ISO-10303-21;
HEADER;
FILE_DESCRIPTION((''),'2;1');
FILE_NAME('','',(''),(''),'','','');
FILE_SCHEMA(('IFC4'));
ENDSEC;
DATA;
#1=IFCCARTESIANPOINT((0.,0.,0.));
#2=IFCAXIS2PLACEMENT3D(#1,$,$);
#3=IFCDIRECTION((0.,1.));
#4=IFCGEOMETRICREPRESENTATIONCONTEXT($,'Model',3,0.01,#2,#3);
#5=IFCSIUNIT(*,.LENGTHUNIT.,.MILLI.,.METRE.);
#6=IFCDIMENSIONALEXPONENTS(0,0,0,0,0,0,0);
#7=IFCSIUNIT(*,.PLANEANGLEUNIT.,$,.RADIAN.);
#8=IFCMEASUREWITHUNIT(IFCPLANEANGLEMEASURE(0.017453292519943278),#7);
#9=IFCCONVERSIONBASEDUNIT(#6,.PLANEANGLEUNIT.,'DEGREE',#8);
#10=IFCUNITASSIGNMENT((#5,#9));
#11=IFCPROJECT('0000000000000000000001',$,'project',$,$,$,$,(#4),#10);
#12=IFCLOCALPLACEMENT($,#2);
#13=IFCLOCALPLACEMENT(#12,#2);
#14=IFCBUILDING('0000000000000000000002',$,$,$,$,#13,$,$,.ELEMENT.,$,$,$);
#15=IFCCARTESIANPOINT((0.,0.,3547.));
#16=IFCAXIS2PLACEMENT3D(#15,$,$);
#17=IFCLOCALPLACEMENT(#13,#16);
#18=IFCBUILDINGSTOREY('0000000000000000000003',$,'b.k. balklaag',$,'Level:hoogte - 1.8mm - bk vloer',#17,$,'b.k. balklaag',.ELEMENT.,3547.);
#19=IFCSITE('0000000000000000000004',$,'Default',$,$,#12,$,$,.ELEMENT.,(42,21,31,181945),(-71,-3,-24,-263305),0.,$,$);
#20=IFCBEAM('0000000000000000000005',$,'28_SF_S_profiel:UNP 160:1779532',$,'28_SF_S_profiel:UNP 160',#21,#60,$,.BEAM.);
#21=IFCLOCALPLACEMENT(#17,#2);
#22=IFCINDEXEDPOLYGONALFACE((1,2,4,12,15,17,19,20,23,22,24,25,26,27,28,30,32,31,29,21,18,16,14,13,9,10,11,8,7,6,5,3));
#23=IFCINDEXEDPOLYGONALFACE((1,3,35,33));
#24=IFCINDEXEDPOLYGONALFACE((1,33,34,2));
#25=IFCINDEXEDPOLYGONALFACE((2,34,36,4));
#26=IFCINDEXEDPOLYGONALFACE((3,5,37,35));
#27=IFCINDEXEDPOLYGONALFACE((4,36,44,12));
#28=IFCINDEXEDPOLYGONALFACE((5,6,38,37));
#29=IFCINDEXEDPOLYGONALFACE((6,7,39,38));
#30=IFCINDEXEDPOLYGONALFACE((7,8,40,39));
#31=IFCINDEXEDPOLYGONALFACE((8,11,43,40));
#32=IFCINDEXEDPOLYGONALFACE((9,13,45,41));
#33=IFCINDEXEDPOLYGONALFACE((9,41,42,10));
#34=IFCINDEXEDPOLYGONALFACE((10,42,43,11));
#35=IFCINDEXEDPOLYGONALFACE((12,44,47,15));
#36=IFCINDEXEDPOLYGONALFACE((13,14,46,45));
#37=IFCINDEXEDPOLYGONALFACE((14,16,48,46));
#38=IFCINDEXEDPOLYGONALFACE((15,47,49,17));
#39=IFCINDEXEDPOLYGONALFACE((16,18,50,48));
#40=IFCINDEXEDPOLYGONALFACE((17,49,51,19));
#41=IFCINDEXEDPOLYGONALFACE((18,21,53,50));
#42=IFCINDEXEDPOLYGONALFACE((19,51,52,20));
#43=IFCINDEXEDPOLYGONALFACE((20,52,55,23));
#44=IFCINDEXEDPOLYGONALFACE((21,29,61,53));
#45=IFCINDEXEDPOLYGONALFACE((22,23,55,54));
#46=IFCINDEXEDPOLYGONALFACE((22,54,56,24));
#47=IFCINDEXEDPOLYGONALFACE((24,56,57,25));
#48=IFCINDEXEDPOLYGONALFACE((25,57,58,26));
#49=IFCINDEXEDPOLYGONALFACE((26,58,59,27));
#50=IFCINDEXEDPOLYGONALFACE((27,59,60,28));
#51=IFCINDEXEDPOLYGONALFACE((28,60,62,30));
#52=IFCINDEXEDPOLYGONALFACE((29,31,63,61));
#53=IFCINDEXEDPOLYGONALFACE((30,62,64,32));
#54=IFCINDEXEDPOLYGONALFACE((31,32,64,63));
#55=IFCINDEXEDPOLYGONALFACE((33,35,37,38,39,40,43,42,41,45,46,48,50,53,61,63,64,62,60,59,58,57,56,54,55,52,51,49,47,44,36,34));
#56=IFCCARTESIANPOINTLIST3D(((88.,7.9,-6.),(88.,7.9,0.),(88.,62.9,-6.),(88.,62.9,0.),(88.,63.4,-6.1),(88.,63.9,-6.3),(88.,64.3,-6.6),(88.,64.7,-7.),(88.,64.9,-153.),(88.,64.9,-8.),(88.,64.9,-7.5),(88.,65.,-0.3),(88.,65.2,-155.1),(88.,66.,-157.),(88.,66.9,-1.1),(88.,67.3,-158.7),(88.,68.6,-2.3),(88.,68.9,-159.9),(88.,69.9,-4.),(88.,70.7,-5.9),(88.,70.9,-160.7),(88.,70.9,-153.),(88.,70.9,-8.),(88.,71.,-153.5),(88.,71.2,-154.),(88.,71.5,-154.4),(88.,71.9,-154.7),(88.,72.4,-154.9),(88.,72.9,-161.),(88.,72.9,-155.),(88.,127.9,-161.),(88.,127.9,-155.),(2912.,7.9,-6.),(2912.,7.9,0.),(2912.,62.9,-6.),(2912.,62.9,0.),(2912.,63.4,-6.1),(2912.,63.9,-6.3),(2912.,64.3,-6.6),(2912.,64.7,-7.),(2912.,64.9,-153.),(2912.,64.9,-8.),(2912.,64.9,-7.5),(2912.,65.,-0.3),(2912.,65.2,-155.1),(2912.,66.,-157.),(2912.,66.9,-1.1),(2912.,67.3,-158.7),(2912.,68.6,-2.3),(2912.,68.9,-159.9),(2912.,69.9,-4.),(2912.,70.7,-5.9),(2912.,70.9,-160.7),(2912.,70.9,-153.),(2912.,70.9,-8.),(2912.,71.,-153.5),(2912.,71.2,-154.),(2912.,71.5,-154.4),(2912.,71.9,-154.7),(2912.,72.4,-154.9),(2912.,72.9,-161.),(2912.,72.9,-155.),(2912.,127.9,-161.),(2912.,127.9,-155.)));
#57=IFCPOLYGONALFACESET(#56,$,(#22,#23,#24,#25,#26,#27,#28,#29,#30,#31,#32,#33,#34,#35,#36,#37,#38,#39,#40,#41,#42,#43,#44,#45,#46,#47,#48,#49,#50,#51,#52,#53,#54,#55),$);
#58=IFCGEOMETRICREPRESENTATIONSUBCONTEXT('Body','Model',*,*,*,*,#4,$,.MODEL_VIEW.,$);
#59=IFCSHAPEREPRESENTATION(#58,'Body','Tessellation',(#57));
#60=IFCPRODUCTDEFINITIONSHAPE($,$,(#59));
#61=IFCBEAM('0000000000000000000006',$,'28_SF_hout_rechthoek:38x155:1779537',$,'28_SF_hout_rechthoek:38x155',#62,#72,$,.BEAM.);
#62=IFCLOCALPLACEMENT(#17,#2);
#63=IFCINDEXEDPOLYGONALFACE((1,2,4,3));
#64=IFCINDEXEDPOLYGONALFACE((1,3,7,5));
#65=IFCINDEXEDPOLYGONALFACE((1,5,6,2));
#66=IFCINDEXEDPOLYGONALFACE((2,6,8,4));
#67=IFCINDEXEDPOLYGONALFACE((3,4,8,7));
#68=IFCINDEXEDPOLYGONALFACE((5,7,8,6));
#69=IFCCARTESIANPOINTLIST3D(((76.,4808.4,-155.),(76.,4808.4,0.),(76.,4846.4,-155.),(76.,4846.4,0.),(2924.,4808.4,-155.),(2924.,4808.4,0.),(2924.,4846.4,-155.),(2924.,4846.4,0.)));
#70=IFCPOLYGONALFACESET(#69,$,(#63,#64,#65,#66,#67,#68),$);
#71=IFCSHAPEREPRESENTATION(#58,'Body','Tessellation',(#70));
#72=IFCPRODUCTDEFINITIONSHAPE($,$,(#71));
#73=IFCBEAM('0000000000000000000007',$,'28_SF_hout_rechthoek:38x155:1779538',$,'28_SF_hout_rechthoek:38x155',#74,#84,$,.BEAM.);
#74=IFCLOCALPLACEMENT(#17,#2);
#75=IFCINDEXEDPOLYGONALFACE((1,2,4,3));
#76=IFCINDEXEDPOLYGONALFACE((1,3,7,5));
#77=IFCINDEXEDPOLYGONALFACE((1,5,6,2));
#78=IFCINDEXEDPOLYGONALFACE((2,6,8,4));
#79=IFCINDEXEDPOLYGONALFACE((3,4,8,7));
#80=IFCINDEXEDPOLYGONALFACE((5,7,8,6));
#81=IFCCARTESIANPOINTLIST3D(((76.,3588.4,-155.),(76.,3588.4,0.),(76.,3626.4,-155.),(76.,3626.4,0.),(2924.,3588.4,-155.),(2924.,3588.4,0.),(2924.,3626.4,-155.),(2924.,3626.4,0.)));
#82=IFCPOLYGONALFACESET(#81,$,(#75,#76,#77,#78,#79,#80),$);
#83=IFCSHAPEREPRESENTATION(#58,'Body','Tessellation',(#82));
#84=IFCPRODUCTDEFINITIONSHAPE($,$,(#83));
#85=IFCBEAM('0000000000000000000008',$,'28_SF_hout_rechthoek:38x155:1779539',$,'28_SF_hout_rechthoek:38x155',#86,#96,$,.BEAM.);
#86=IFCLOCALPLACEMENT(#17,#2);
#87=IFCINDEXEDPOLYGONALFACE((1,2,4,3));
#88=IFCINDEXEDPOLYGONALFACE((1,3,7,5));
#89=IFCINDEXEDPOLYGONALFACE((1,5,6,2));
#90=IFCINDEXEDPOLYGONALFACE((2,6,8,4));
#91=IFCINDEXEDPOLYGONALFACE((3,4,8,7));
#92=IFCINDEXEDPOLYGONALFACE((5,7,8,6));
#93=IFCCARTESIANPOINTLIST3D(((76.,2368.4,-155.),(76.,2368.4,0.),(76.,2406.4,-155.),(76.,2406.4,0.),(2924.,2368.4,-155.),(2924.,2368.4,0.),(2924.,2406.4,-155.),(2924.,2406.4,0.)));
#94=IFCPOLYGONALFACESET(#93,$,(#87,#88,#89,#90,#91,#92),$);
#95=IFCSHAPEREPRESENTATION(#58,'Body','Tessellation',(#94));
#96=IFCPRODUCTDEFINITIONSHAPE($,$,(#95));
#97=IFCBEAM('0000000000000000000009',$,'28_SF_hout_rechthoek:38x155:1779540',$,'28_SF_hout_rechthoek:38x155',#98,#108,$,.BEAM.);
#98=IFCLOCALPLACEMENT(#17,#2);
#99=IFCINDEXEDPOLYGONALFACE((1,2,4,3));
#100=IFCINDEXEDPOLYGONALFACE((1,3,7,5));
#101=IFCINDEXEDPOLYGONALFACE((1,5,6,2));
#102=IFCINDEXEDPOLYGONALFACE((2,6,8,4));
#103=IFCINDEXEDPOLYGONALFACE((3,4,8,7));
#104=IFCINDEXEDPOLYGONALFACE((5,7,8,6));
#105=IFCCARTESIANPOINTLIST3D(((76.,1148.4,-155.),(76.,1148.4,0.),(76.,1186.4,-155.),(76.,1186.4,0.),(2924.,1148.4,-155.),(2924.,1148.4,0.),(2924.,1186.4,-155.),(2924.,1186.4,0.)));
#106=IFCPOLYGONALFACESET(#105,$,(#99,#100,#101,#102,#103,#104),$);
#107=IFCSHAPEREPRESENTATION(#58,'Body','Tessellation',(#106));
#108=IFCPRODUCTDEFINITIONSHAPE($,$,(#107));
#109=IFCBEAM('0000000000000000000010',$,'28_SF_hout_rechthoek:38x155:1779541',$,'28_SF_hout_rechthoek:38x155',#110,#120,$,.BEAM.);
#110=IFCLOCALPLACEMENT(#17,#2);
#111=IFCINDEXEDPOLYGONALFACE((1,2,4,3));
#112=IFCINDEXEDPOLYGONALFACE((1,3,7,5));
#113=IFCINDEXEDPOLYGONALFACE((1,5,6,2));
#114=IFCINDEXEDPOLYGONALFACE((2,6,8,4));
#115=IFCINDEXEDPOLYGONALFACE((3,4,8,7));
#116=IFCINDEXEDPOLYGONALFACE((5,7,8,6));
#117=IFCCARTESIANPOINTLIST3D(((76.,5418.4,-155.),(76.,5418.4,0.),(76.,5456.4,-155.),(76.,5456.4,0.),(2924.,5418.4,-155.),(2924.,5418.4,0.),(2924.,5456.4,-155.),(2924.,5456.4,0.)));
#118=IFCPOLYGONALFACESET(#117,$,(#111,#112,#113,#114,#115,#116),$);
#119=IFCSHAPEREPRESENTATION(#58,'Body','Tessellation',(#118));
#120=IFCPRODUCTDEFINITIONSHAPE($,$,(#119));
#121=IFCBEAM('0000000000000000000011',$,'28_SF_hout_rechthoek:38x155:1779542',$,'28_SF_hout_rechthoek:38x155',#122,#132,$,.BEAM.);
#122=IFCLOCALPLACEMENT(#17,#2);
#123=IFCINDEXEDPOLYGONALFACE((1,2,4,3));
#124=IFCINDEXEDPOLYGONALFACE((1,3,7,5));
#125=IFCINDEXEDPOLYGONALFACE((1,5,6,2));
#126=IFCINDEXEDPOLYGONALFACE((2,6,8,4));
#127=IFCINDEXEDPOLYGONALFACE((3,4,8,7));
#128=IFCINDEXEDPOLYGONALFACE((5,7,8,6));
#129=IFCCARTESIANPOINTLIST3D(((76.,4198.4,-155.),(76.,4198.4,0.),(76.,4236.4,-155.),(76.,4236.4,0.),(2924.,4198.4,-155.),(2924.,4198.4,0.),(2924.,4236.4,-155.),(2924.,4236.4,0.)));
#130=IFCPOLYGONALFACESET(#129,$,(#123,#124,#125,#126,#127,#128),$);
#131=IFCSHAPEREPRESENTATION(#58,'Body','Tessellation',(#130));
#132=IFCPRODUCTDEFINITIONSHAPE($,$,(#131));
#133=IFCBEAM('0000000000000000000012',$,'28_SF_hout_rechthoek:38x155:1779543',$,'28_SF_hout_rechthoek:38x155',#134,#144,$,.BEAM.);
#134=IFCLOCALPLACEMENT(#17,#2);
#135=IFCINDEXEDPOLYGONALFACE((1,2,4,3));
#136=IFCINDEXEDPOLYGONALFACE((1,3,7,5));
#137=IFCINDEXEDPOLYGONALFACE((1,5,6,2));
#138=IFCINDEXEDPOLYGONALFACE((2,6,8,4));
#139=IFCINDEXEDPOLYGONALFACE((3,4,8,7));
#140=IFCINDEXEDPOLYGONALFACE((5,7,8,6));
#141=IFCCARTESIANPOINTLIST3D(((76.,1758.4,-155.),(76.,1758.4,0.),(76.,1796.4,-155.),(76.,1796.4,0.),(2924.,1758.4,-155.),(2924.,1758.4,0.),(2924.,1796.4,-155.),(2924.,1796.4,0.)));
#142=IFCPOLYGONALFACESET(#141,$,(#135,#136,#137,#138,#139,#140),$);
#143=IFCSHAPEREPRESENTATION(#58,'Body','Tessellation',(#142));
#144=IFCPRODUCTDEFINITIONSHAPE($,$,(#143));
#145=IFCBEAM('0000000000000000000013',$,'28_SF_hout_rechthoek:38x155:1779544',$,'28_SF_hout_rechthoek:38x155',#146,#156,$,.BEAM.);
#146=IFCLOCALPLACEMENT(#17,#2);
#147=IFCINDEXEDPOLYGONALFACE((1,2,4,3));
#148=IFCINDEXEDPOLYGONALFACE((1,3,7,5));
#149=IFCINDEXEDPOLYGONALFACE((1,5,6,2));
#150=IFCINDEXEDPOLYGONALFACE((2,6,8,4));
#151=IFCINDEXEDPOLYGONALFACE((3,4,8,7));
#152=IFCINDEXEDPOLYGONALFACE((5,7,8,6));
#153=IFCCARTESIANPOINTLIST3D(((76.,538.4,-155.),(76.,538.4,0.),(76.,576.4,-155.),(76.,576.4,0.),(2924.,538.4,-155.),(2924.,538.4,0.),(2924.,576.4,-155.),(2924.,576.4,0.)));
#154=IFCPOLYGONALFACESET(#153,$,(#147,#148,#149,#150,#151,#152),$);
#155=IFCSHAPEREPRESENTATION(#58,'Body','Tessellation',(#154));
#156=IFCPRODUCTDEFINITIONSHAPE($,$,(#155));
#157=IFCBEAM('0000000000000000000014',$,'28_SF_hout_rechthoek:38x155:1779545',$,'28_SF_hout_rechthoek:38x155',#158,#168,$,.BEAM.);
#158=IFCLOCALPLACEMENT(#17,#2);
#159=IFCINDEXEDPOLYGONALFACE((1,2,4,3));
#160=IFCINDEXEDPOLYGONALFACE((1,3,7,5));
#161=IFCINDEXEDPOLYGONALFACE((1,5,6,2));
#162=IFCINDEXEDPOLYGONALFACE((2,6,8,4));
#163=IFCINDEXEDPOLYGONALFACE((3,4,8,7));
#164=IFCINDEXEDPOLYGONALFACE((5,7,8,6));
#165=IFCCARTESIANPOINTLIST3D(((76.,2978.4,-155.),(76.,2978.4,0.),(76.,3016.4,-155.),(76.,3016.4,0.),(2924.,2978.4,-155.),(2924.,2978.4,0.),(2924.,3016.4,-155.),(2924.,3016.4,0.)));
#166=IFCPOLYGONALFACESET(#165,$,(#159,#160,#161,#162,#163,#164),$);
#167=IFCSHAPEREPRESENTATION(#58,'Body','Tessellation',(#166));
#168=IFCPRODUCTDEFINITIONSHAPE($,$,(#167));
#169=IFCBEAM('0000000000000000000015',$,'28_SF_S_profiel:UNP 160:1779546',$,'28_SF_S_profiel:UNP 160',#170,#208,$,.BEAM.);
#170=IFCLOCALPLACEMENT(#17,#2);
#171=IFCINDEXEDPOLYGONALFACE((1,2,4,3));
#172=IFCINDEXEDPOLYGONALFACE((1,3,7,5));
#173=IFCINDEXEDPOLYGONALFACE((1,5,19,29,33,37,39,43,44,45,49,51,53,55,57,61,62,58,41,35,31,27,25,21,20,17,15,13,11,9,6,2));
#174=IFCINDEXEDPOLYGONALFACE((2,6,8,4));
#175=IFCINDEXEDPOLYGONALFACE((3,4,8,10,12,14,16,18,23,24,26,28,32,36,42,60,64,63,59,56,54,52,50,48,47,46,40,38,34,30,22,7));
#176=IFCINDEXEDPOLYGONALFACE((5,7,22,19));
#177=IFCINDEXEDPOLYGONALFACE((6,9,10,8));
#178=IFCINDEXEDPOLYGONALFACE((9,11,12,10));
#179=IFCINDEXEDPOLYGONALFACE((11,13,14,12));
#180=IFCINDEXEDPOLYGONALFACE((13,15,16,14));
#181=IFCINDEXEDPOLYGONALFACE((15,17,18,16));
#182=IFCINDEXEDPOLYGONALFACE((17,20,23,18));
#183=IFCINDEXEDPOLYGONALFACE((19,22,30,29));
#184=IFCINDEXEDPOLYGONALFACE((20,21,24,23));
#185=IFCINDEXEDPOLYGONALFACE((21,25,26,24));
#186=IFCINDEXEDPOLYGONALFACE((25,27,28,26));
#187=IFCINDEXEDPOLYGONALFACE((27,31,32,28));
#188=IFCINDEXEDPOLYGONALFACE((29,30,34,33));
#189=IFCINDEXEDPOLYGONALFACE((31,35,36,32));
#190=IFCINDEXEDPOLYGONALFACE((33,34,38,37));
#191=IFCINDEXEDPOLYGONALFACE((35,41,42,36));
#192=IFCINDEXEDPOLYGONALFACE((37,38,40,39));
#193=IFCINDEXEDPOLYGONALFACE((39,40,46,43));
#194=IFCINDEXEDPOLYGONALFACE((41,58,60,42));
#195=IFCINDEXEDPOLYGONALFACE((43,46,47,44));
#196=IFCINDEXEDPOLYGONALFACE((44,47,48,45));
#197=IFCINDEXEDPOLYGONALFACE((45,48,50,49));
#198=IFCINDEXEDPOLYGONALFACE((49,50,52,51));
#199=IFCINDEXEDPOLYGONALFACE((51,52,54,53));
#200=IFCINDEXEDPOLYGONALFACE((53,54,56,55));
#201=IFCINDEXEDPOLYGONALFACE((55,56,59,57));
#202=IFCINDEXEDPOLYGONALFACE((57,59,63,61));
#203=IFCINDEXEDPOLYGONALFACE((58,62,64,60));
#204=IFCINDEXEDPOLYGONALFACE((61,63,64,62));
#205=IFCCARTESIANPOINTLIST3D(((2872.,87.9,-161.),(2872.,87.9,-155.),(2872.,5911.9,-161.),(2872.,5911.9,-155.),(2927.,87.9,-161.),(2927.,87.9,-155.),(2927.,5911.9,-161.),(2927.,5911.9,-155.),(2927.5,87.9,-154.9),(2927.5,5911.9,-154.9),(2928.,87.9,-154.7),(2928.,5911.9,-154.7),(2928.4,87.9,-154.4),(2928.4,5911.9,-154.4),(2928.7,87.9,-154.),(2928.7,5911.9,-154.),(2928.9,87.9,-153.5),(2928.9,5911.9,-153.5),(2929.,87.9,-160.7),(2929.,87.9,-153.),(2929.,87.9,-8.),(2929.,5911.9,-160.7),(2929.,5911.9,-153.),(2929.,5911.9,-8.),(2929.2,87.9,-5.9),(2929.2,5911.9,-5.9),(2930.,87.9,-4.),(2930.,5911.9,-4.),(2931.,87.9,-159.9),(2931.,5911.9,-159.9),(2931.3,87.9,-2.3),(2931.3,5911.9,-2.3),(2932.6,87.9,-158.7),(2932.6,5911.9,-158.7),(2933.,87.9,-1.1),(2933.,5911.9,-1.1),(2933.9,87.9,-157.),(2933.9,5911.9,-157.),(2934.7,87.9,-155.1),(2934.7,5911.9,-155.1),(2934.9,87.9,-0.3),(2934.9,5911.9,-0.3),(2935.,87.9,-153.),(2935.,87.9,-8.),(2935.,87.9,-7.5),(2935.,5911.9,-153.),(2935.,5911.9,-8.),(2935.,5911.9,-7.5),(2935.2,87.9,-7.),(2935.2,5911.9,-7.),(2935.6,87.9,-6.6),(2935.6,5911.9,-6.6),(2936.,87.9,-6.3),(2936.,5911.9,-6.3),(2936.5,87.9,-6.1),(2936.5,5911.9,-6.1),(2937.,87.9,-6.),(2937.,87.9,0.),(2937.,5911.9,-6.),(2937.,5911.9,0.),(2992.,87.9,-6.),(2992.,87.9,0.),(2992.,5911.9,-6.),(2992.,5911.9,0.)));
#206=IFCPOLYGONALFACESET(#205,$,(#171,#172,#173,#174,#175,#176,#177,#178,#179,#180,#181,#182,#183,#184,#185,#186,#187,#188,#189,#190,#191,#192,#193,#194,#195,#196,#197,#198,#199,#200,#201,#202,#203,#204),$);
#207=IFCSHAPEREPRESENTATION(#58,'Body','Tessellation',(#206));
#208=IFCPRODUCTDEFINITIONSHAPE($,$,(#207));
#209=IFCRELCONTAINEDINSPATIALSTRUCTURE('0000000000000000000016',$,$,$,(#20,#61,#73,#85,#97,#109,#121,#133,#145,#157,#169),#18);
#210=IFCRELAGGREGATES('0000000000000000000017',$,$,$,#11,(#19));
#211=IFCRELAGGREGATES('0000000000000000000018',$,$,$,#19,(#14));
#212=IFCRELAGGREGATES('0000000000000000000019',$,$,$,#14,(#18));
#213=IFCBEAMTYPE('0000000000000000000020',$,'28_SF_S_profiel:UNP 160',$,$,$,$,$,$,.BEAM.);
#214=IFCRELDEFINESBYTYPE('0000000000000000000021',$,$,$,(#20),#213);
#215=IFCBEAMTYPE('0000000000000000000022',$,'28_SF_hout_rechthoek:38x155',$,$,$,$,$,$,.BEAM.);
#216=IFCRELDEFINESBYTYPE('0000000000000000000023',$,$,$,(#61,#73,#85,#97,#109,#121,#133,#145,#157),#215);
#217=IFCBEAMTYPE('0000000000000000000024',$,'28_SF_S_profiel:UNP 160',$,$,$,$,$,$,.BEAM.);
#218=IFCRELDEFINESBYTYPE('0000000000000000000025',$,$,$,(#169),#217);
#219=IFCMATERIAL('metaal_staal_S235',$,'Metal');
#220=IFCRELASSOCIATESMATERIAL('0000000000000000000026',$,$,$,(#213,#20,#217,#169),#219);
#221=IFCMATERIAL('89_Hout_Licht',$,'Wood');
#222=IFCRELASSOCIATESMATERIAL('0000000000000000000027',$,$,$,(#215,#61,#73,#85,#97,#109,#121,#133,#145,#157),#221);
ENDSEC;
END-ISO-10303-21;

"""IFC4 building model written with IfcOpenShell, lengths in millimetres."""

from ifc_helpers import new_model, entity, si_unit, converted_unit, direction, frame, origin, place, context, subcontext, project, spatial, line, arc, indexed_curve, outline, extrude, source, transform, mapped, material, type_object, type_shapes, element, save


model = new_model("IFC4")

# Units and contexts
model_context = context("Model", 3, precision=0.01, world=origin(), true_north=direction((0.0, 1.0)))
body_context = subcontext(model_context, "Body", "Model", "MODEL_VIEW")
ifc_project = project(units=[si_unit("LENGTHUNIT", "METRE", prefix="MILLI"), converted_unit("PLANEANGLEUNIT", "DEGREE", entity("IfcPlaneAngleMeasure", 0.017453292519943278), si_unit("PLANEANGLEUNIT", "RADIAN"), dimensions=[0, 0, 0, 0, 0, 0, 0])], contexts=[model_context])

# Site, building, storey
site_placement = place(None, origin())
site = spatial("IfcSite", under=ifc_project, at=site_placement, Name="Default", CompositionType="ELEMENT", RefLatitude=(42, 21, 31, 181945), RefLongitude=(-71, -3, -24, -263305), RefElevation=0.0)
building_placement = place(site_placement, origin())
building = spatial("IfcBuilding", under=site, at=building_placement, CompositionType="ELEMENT")
storey_placement = place(building_placement, frame((0.0, 0.0, 3547.0)))
storey = spatial("IfcBuildingStorey", under=building, at=storey_placement, Name="b.k. balklaag", ObjectType="Level:hoogte - 1.8mm - bk vloer", LongName="b.k. balklaag", CompositionType="ELEMENT", Elevation=3547.0)

# Beams
ifc_material_1 = material(Name="metaal_staal_S235", Category="Metal")
beam_type_1 = type_object("IfcBeamType", Name="28_SF_S_profiel:UNP 160", PredefinedType="BEAM", material=ifc_material_1)
shared_shape_1 = source(origin(), body_context, "Body", "SweptSolid", [
    extrude(outline(indexed_curve([(-80.5, -60.0), (-74.5, -60.0), (-74.5, -5.0), (-73.9, -3.6), (-72.5, -3.0), (72.5, -3.0), (78.2, -0.7), (80.5, 5.0), (80.5, 60.0), (74.5, 60.0), (74.5, 5.0), (73.9, 3.6), (72.5, 3.0), (-72.5, 3.0), (-78.2, 0.7), (-80.5, -5.0)], segments=[line(1, 2, 3), arc(3, 4, 5), line(5, 6), arc(6, 7, 8), line(8, 9, 10, 11), arc(11, 12, 13), line(13, 14), arc(14, 15, 16), line(16, 1)], self_intersect=False)), frame((-1412.0, 49.0, -4.5), z_axis=(1.0, 0.0, 0.0), x_axis=(0.0, 0.0, -1.0)), (0.0, 0.0, 1.0), 2824.0),
])
type_shapes(beam_type_1, [shared_shape_1])
beam_1_placement = place(storey_placement, frame((1500.0, 18.9, -76.0)))
element("IfcBeam", 1, at=beam_1_placement, inside=storey, type_object=beam_type_1, material=ifc_material_1, Name="28_SF_S_profiel:UNP 160:1779532", ObjectType="28_SF_S_profiel:UNP 160", PredefinedType="BEAM", context=body_context, shape_type="MappedRepresentation", body=[
    mapped(shared_shape_1, transform((0.0, 0.0, 0.0), scale=1.0)),
])
ifc_material_2 = material(Name="89_Hout_Licht", Category="Wood")
beam_type_2 = type_object("IfcBeamType", Name="28_SF_hout_rechthoek:38x155", PredefinedType="BEAM", material=ifc_material_2)
shared_shape_2 = source(origin(), body_context, "Body", "SweptSolid", [
    extrude(outline(indexed_curve([(-1424.0, -19.0), (1424.0, -19.0), (1424.0, 19.0), (-1424.0, 19.0), (-1424.0, -19.0)], self_intersect=False)), frame((0.0, 0.0, -77.5), z_axis=(0.0, 0.0, 1.0), x_axis=(-1.0, 0.0, 0.0)), (0.0, 0.0, 1.0), 155.0),
])
type_shapes(beam_type_2, [shared_shape_2])
for number, where, name in (
    (2, (1500.0, 4827.4, -77.5), "28_SF_hout_rechthoek:38x155:1779537"),
    (3, (1500.0, 3607.4, -77.5), "28_SF_hout_rechthoek:38x155:1779538"),
    (4, (1500.0, 2387.4, -77.5), "28_SF_hout_rechthoek:38x155:1779539"),
    (5, (1500.0, 1167.4, -77.5), "28_SF_hout_rechthoek:38x155:1779540"),
    (6, (1500.0, 5437.4, -77.5), "28_SF_hout_rechthoek:38x155:1779541"),
    (7, (1500.0, 4217.4, -77.5), "28_SF_hout_rechthoek:38x155:1779542"),
    (8, (1500.0, 1777.4, -77.5), "28_SF_hout_rechthoek:38x155:1779543"),
    (9, (1500.0, 557.4, -77.5), "28_SF_hout_rechthoek:38x155:1779544"),
    (10, (1500.0, 2997.4, -77.5), "28_SF_hout_rechthoek:38x155:1779545"),
):
    element("IfcBeam", number, at=place(storey_placement, frame(where)), inside=storey, type_object=beam_type_2, material=ifc_material_2, Name=name, ObjectType="28_SF_hout_rechthoek:38x155", PredefinedType="BEAM", context=body_context, shape_type="MappedRepresentation", body=[
        mapped(shared_shape_2, transform((0.0, 0.0, 0.0), scale=1.0)),
    ])
beam_type_3 = type_object("IfcBeamType", Name="28_SF_S_profiel:UNP 160", PredefinedType="BEAM", material=ifc_material_1)
shared_shape_3 = source(origin(), body_context, "Body", "SweptSolid", [
    extrude(outline(indexed_curve([(-80.5, -60.0), (-74.5, -60.0), (-74.5, -5.0), (-73.9, -3.6), (-72.5, -3.0), (72.5, -3.0), (78.2, -0.7), (80.5, 5.0), (80.5, 60.0), (74.5, 60.0), (74.5, 5.0), (73.9, 3.6), (72.5, 3.0), (-72.5, 3.0), (-78.2, 0.7), (-80.5, -5.0)], segments=[line(1, 2, 3), arc(3, 4, 5), line(5, 6), arc(6, 7, 8), line(8, 9, 10, 11), arc(11, 12, 13), line(13, 14), arc(14, 15, 16), line(16, 1)], self_intersect=False)), frame((-2912.0, 49.0, -4.5), z_axis=(1.0, 0.0, 0.0), x_axis=(0.0, 0.0, -1.0)), (0.0, 0.0, 1.0), 5824.0),
])
type_shapes(beam_type_3, [shared_shape_3])
beam_2_placement = place(storey_placement, frame((2981.0, 2999.9, -76.0), z_axis=(0.0, 0.0, 1.0), x_axis=(0.0, 1.0, 0.0)))
element("IfcBeam", 11, at=beam_2_placement, inside=storey, type_object=beam_type_3, material=ifc_material_1, Name="28_SF_S_profiel:UNP 160:1779546", ObjectType="28_SF_S_profiel:UNP 160", PredefinedType="BEAM", context=body_context, shape_type="MappedRepresentation", body=[
    mapped(shared_shape_3, transform((0.0, 0.0, 0.0), scale=1.0)),
])

save(model, "model.ifc")
